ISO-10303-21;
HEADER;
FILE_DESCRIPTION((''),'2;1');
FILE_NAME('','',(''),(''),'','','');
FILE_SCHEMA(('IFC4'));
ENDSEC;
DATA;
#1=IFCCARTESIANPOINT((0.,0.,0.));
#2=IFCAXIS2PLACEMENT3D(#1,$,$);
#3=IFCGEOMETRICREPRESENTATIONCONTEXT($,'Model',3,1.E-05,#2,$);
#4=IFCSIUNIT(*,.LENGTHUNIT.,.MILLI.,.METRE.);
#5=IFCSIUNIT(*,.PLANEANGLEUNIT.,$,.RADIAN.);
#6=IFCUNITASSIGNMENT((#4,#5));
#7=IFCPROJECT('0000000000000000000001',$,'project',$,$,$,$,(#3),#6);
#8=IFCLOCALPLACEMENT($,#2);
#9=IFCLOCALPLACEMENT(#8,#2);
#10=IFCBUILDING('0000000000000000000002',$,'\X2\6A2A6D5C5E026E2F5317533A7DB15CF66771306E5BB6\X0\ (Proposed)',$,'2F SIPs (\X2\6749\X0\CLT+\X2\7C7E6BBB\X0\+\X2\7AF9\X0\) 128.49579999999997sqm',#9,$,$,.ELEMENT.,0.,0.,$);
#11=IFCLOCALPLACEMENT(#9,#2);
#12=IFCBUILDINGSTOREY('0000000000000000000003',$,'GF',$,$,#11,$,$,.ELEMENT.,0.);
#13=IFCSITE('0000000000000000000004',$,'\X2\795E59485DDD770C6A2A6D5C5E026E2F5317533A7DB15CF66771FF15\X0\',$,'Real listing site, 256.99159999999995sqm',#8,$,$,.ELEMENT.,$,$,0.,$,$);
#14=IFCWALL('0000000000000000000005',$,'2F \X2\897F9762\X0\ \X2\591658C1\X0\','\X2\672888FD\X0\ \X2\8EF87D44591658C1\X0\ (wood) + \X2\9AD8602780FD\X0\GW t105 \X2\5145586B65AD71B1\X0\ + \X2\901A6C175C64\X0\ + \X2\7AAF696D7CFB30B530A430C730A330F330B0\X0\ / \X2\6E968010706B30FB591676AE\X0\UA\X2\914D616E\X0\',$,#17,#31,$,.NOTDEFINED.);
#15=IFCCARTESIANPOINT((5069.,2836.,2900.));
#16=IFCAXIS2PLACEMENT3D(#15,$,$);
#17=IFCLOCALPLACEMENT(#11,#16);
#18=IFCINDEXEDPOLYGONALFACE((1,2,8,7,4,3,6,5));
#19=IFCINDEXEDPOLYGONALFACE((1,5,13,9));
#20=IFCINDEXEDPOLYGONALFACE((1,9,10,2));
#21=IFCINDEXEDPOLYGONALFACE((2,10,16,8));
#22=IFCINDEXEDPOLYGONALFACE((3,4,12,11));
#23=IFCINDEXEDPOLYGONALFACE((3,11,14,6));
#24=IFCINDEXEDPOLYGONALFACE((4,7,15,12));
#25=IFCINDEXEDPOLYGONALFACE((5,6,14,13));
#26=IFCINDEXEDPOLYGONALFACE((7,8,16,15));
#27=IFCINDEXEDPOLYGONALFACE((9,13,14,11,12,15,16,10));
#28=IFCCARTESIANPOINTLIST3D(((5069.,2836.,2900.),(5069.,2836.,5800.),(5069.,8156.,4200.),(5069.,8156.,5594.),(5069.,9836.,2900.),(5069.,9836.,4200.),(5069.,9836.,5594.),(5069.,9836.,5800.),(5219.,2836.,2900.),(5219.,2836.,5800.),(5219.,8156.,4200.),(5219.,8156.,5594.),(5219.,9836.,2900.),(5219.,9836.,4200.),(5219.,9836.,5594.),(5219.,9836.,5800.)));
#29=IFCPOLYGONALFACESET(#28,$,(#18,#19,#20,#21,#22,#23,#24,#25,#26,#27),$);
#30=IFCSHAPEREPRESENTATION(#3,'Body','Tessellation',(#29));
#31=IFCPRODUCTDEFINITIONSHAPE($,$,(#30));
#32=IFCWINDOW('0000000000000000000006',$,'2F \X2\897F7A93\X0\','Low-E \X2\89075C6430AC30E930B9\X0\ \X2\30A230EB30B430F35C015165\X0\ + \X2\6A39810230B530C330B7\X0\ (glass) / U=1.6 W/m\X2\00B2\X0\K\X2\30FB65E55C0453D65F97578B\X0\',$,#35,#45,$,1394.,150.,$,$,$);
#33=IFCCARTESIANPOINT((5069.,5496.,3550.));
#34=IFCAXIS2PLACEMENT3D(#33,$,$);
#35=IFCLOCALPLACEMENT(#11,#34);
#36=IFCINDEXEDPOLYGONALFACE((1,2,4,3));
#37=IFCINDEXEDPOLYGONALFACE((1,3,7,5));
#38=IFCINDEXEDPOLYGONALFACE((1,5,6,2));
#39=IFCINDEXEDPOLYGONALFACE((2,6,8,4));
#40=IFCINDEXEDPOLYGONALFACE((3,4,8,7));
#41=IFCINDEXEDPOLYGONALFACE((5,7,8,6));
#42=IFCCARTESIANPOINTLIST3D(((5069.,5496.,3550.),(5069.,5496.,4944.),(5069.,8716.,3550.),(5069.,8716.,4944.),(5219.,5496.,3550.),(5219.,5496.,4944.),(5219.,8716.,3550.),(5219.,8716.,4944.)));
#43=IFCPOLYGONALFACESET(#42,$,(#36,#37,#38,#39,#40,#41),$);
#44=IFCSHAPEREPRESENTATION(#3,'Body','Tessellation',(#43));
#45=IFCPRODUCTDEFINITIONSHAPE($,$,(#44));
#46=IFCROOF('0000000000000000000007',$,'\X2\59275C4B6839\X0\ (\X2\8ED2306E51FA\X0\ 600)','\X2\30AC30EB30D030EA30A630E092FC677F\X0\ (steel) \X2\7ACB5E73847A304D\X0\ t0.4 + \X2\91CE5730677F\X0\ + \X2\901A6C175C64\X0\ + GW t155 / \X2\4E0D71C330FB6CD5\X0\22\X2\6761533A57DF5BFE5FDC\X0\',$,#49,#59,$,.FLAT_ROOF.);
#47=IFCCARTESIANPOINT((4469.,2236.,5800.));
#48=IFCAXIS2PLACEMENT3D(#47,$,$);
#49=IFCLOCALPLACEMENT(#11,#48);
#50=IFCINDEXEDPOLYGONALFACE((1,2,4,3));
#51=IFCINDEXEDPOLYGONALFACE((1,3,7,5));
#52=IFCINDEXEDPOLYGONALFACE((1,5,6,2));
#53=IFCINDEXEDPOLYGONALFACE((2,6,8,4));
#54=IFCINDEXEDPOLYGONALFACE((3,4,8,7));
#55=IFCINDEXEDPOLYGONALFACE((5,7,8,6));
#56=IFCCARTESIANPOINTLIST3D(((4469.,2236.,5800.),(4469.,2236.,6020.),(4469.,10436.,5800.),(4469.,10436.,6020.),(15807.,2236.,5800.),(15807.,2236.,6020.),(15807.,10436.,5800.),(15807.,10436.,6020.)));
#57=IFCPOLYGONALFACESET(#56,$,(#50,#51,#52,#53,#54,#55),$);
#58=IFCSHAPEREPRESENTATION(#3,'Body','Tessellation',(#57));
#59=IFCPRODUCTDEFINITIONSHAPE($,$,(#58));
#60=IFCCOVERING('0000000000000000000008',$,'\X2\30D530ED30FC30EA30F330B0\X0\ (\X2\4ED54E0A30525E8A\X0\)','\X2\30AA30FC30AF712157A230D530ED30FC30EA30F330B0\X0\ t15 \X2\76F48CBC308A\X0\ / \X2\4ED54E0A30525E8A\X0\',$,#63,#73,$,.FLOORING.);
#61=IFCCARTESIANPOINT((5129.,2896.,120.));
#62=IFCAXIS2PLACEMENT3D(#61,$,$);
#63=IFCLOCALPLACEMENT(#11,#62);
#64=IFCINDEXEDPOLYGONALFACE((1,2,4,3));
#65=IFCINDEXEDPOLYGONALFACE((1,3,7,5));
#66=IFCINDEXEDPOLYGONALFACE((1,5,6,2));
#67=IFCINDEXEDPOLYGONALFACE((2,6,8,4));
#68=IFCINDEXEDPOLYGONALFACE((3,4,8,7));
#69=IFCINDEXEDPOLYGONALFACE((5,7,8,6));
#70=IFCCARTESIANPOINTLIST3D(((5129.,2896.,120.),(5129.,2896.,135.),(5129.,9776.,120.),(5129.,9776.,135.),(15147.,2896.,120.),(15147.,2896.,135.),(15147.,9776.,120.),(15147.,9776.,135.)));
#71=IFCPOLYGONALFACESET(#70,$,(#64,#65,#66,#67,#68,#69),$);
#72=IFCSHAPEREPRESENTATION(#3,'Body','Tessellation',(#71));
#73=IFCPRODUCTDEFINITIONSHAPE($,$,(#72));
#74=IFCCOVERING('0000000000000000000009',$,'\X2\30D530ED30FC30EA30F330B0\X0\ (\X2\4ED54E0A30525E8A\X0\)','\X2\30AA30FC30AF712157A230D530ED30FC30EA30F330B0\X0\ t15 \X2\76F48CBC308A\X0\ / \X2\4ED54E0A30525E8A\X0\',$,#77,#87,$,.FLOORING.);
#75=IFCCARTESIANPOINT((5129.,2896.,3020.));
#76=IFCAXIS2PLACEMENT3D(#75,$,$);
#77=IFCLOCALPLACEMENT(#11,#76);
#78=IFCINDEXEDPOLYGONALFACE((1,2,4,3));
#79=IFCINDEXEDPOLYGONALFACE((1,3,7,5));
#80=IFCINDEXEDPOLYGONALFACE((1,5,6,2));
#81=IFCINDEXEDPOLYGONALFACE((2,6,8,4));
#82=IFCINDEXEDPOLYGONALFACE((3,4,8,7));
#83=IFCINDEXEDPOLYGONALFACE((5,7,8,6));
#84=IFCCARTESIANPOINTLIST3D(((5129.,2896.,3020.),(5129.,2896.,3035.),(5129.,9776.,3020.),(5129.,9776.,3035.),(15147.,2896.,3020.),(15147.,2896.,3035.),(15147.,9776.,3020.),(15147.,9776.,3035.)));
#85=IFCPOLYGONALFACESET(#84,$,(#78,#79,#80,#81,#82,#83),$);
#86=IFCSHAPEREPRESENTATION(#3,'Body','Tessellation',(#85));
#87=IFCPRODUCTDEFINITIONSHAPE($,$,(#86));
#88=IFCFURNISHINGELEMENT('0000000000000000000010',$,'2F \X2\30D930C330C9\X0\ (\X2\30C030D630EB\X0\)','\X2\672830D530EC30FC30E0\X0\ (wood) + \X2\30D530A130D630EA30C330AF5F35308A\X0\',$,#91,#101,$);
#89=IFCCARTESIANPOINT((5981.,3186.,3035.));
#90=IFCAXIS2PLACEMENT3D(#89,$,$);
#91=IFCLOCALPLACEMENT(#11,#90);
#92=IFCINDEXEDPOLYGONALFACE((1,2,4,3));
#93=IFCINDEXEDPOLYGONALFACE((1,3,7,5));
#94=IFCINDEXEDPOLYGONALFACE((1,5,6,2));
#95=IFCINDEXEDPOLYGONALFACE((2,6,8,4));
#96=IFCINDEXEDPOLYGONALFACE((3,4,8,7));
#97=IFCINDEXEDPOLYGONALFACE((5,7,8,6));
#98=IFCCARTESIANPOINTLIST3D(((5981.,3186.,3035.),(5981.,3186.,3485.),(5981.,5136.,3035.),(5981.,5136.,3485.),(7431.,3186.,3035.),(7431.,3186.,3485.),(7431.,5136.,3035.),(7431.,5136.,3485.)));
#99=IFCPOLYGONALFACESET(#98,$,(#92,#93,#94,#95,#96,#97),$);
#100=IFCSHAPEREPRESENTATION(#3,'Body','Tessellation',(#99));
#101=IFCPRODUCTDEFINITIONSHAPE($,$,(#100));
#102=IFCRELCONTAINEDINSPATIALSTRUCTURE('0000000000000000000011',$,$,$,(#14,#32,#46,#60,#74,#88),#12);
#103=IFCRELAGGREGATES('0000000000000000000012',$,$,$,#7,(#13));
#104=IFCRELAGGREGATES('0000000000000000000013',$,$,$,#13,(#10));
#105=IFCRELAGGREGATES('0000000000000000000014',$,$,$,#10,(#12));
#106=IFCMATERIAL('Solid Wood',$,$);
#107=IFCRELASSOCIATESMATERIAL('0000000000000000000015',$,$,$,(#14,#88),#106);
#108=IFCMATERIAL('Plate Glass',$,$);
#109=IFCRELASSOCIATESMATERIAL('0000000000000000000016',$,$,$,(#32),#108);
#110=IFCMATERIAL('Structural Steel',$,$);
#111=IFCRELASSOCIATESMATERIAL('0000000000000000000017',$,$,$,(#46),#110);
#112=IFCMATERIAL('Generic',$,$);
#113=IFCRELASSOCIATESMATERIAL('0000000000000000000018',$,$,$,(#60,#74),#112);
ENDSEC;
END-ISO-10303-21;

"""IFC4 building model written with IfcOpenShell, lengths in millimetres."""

from ifc_helpers import new_model, si_unit, frame, frame_2d, origin, place, context, project, spatial, rectangle, extrude, material, element, fill, save


model = new_model("IFC4")

# Units and contexts
model_context = context("Model", 3, precision=1e-05, world=origin())
ifc_project = project(units=[si_unit("LENGTHUNIT", "METRE", prefix="MILLI"), si_unit("PLANEANGLEUNIT", "RADIAN")], contexts=[model_context])

# Site, building, storey
site_placement = place(None, origin())
site = spatial("IfcSite", under=ifc_project, at=site_placement, Name="神奈川県横浜市港北区綱島東５", ObjectType="Real listing site, 256.99159999999995sqm", CompositionType="ELEMENT", RefElevation=0.0)
building_placement = place(site_placement, origin())
building = spatial("IfcBuilding", under=site, at=building_placement, Name="横浜市港北区綱島東の家 (Proposed)", ObjectType="2F SIPs (杉CLT+籾殻+竹) 128.49579999999997sqm", CompositionType="ELEMENT", ElevationOfRefHeight=0.0, ElevationOfTerrain=0.0)
storey_placement = place(building_placement, origin())
storey = spatial("IfcBuildingStorey", under=building, at=storey_placement, Name="GF", CompositionType="ELEMENT", Elevation=0.0)

# Shared definitions
ifc_material_1 = material(Name="Solid Wood")

# Shared definitions
ifc_material_2 = material(Name="Plate Glass")

# Wall, opening, window
wall_1_placement = place(storey_placement, frame((5069.0, 2836.0, 2900.0)))
wall_1 = element("IfcWall", 1, at=wall_1_placement, inside=storey, material=ifc_material_1, Name="2F 西面 外壁", Description="木製 軸組外壁 (wood) + 高性能GW t105 充填断熱 + 通気層 + 窯業系サイディング / 準耐火・外皮UA配慮", PredefinedType="NOTDEFINED", context=model_context, shape_type="SweptSolid", body=[
    extrude(rectangle(XDim=150.0, YDim=7000.0, at=frame_2d((75.0, 3500.0))), frame((5069.0, 2836.0, 2900.0)), (0.0, 0.0, 1.0), 2900.0),
])
opening_1_placement = place(storey_placement, frame((5069.0, 5496.0, 3550.0)))
opening_1 = element("IfcOpeningElement", 2, at=opening_1_placement, cuts=wall_1, PredefinedType="NOTDEFINED", context=model_context, shape_type="SweptSolid", body=[
    extrude(rectangle(XDim=150.0, YDim=3220.0, at=frame_2d((75.0, 1610.0))), frame((5069.0, 5496.0, 3550.0)), (0.0, 0.0, 1.0), 1394.0),
])
window_1_placement = place(storey_placement, frame((5069.0, 5496.0, 3550.0)))
window_1 = element("IfcWindow", 3, at=window_1_placement, inside=storey, material=ifc_material_2, Name="2F 西窓", Description="Low-E 複層ガラス アルゴン封入 + 樹脂サッシ (glass) / U=1.6 W/m²K・日射取得型", OverallHeight=1394.0, OverallWidth=150.0, context=model_context, shape_type="SweptSolid", body=[
    extrude(rectangle(XDim=150.0, YDim=3220.0, at=frame_2d((75.0, 1610.0))), frame((5069.0, 5496.0, 3550.0)), (0.0, 0.0, 1.0), 1394.0),
])
fill(opening_1, window_1)

# Roof
ifc_material_3 = material(Name="Structural Steel")
roof_placement = place(storey_placement, frame((4469.0, 2236.0, 5800.0)))
element("IfcRoof", 4, at=roof_placement, inside=storey, material=ifc_material_3, Name="大屋根 (軒の出 600)", Description="ガルバリウム鋼板 (steel) 立平葺き t0.4 + 野地板 + 通気層 + GW t155 / 不燃・法22条区域対応", PredefinedType="FLAT_ROOF", context=model_context, shape_type="SweptSolid", body=[
    extrude(rectangle(XDim=11338.0, YDim=8200.0, at=frame_2d((5669.0, 4100.0))), frame((4469.0, 2236.0, 5800.0)), (0.0, 0.0, 1.0), 220.0),
])

# Coverings
ifc_material_4 = material(Name="Generic")
covering_1_placement = place(storey_placement, frame((5129.0, 2896.0, 120.0)))
element("IfcCovering", 5, at=covering_1_placement, inside=storey, material=ifc_material_4, Name="フローリング (仕上げ床)", Description="オーク無垢フローリング t15 直貼り / 仕上げ床", PredefinedType="FLOORING", context=model_context, shape_type="SweptSolid", body=[
    extrude(rectangle(XDim=10018.0, YDim=6880.0, at=frame_2d((5009.0, 3440.0))), frame((5129.0, 2896.0, 120.0)), (0.0, 0.0, 1.0), 15.0),
])
covering_2_placement = place(storey_placement, frame((5129.0, 2896.0, 3020.0)))
element("IfcCovering", 6, at=covering_2_placement, inside=storey, material=ifc_material_4, Name="フローリング (仕上げ床)", Description="オーク無垢フローリング t15 直貼り / 仕上げ床", PredefinedType="FLOORING", context=model_context, shape_type="SweptSolid", body=[
    extrude(rectangle(XDim=10018.0, YDim=6880.0, at=frame_2d((5009.0, 3440.0))), frame((5129.0, 2896.0, 3020.0)), (0.0, 0.0, 1.0), 15.0),
])

# Furnishing element
furnishing_placement = place(storey_placement, frame((5981.0, 3186.0, 3035.0)))
element("IfcFurnishingElement", 7, at=furnishing_placement, inside=storey, material=ifc_material_1, Name="2F ベッド (ダブル)", Description="木フレーム (wood) + ファブリック張り", context=model_context, shape_type="SweptSolid", body=[
    extrude(rectangle(XDim=1450.0, YDim=1950.0, at=frame_2d((725.0, 975.0))), frame((5981.0, 3186.0, 3035.0)), (0.0, 0.0, 1.0), 450.0),
])

save(model, "model.ifc")
